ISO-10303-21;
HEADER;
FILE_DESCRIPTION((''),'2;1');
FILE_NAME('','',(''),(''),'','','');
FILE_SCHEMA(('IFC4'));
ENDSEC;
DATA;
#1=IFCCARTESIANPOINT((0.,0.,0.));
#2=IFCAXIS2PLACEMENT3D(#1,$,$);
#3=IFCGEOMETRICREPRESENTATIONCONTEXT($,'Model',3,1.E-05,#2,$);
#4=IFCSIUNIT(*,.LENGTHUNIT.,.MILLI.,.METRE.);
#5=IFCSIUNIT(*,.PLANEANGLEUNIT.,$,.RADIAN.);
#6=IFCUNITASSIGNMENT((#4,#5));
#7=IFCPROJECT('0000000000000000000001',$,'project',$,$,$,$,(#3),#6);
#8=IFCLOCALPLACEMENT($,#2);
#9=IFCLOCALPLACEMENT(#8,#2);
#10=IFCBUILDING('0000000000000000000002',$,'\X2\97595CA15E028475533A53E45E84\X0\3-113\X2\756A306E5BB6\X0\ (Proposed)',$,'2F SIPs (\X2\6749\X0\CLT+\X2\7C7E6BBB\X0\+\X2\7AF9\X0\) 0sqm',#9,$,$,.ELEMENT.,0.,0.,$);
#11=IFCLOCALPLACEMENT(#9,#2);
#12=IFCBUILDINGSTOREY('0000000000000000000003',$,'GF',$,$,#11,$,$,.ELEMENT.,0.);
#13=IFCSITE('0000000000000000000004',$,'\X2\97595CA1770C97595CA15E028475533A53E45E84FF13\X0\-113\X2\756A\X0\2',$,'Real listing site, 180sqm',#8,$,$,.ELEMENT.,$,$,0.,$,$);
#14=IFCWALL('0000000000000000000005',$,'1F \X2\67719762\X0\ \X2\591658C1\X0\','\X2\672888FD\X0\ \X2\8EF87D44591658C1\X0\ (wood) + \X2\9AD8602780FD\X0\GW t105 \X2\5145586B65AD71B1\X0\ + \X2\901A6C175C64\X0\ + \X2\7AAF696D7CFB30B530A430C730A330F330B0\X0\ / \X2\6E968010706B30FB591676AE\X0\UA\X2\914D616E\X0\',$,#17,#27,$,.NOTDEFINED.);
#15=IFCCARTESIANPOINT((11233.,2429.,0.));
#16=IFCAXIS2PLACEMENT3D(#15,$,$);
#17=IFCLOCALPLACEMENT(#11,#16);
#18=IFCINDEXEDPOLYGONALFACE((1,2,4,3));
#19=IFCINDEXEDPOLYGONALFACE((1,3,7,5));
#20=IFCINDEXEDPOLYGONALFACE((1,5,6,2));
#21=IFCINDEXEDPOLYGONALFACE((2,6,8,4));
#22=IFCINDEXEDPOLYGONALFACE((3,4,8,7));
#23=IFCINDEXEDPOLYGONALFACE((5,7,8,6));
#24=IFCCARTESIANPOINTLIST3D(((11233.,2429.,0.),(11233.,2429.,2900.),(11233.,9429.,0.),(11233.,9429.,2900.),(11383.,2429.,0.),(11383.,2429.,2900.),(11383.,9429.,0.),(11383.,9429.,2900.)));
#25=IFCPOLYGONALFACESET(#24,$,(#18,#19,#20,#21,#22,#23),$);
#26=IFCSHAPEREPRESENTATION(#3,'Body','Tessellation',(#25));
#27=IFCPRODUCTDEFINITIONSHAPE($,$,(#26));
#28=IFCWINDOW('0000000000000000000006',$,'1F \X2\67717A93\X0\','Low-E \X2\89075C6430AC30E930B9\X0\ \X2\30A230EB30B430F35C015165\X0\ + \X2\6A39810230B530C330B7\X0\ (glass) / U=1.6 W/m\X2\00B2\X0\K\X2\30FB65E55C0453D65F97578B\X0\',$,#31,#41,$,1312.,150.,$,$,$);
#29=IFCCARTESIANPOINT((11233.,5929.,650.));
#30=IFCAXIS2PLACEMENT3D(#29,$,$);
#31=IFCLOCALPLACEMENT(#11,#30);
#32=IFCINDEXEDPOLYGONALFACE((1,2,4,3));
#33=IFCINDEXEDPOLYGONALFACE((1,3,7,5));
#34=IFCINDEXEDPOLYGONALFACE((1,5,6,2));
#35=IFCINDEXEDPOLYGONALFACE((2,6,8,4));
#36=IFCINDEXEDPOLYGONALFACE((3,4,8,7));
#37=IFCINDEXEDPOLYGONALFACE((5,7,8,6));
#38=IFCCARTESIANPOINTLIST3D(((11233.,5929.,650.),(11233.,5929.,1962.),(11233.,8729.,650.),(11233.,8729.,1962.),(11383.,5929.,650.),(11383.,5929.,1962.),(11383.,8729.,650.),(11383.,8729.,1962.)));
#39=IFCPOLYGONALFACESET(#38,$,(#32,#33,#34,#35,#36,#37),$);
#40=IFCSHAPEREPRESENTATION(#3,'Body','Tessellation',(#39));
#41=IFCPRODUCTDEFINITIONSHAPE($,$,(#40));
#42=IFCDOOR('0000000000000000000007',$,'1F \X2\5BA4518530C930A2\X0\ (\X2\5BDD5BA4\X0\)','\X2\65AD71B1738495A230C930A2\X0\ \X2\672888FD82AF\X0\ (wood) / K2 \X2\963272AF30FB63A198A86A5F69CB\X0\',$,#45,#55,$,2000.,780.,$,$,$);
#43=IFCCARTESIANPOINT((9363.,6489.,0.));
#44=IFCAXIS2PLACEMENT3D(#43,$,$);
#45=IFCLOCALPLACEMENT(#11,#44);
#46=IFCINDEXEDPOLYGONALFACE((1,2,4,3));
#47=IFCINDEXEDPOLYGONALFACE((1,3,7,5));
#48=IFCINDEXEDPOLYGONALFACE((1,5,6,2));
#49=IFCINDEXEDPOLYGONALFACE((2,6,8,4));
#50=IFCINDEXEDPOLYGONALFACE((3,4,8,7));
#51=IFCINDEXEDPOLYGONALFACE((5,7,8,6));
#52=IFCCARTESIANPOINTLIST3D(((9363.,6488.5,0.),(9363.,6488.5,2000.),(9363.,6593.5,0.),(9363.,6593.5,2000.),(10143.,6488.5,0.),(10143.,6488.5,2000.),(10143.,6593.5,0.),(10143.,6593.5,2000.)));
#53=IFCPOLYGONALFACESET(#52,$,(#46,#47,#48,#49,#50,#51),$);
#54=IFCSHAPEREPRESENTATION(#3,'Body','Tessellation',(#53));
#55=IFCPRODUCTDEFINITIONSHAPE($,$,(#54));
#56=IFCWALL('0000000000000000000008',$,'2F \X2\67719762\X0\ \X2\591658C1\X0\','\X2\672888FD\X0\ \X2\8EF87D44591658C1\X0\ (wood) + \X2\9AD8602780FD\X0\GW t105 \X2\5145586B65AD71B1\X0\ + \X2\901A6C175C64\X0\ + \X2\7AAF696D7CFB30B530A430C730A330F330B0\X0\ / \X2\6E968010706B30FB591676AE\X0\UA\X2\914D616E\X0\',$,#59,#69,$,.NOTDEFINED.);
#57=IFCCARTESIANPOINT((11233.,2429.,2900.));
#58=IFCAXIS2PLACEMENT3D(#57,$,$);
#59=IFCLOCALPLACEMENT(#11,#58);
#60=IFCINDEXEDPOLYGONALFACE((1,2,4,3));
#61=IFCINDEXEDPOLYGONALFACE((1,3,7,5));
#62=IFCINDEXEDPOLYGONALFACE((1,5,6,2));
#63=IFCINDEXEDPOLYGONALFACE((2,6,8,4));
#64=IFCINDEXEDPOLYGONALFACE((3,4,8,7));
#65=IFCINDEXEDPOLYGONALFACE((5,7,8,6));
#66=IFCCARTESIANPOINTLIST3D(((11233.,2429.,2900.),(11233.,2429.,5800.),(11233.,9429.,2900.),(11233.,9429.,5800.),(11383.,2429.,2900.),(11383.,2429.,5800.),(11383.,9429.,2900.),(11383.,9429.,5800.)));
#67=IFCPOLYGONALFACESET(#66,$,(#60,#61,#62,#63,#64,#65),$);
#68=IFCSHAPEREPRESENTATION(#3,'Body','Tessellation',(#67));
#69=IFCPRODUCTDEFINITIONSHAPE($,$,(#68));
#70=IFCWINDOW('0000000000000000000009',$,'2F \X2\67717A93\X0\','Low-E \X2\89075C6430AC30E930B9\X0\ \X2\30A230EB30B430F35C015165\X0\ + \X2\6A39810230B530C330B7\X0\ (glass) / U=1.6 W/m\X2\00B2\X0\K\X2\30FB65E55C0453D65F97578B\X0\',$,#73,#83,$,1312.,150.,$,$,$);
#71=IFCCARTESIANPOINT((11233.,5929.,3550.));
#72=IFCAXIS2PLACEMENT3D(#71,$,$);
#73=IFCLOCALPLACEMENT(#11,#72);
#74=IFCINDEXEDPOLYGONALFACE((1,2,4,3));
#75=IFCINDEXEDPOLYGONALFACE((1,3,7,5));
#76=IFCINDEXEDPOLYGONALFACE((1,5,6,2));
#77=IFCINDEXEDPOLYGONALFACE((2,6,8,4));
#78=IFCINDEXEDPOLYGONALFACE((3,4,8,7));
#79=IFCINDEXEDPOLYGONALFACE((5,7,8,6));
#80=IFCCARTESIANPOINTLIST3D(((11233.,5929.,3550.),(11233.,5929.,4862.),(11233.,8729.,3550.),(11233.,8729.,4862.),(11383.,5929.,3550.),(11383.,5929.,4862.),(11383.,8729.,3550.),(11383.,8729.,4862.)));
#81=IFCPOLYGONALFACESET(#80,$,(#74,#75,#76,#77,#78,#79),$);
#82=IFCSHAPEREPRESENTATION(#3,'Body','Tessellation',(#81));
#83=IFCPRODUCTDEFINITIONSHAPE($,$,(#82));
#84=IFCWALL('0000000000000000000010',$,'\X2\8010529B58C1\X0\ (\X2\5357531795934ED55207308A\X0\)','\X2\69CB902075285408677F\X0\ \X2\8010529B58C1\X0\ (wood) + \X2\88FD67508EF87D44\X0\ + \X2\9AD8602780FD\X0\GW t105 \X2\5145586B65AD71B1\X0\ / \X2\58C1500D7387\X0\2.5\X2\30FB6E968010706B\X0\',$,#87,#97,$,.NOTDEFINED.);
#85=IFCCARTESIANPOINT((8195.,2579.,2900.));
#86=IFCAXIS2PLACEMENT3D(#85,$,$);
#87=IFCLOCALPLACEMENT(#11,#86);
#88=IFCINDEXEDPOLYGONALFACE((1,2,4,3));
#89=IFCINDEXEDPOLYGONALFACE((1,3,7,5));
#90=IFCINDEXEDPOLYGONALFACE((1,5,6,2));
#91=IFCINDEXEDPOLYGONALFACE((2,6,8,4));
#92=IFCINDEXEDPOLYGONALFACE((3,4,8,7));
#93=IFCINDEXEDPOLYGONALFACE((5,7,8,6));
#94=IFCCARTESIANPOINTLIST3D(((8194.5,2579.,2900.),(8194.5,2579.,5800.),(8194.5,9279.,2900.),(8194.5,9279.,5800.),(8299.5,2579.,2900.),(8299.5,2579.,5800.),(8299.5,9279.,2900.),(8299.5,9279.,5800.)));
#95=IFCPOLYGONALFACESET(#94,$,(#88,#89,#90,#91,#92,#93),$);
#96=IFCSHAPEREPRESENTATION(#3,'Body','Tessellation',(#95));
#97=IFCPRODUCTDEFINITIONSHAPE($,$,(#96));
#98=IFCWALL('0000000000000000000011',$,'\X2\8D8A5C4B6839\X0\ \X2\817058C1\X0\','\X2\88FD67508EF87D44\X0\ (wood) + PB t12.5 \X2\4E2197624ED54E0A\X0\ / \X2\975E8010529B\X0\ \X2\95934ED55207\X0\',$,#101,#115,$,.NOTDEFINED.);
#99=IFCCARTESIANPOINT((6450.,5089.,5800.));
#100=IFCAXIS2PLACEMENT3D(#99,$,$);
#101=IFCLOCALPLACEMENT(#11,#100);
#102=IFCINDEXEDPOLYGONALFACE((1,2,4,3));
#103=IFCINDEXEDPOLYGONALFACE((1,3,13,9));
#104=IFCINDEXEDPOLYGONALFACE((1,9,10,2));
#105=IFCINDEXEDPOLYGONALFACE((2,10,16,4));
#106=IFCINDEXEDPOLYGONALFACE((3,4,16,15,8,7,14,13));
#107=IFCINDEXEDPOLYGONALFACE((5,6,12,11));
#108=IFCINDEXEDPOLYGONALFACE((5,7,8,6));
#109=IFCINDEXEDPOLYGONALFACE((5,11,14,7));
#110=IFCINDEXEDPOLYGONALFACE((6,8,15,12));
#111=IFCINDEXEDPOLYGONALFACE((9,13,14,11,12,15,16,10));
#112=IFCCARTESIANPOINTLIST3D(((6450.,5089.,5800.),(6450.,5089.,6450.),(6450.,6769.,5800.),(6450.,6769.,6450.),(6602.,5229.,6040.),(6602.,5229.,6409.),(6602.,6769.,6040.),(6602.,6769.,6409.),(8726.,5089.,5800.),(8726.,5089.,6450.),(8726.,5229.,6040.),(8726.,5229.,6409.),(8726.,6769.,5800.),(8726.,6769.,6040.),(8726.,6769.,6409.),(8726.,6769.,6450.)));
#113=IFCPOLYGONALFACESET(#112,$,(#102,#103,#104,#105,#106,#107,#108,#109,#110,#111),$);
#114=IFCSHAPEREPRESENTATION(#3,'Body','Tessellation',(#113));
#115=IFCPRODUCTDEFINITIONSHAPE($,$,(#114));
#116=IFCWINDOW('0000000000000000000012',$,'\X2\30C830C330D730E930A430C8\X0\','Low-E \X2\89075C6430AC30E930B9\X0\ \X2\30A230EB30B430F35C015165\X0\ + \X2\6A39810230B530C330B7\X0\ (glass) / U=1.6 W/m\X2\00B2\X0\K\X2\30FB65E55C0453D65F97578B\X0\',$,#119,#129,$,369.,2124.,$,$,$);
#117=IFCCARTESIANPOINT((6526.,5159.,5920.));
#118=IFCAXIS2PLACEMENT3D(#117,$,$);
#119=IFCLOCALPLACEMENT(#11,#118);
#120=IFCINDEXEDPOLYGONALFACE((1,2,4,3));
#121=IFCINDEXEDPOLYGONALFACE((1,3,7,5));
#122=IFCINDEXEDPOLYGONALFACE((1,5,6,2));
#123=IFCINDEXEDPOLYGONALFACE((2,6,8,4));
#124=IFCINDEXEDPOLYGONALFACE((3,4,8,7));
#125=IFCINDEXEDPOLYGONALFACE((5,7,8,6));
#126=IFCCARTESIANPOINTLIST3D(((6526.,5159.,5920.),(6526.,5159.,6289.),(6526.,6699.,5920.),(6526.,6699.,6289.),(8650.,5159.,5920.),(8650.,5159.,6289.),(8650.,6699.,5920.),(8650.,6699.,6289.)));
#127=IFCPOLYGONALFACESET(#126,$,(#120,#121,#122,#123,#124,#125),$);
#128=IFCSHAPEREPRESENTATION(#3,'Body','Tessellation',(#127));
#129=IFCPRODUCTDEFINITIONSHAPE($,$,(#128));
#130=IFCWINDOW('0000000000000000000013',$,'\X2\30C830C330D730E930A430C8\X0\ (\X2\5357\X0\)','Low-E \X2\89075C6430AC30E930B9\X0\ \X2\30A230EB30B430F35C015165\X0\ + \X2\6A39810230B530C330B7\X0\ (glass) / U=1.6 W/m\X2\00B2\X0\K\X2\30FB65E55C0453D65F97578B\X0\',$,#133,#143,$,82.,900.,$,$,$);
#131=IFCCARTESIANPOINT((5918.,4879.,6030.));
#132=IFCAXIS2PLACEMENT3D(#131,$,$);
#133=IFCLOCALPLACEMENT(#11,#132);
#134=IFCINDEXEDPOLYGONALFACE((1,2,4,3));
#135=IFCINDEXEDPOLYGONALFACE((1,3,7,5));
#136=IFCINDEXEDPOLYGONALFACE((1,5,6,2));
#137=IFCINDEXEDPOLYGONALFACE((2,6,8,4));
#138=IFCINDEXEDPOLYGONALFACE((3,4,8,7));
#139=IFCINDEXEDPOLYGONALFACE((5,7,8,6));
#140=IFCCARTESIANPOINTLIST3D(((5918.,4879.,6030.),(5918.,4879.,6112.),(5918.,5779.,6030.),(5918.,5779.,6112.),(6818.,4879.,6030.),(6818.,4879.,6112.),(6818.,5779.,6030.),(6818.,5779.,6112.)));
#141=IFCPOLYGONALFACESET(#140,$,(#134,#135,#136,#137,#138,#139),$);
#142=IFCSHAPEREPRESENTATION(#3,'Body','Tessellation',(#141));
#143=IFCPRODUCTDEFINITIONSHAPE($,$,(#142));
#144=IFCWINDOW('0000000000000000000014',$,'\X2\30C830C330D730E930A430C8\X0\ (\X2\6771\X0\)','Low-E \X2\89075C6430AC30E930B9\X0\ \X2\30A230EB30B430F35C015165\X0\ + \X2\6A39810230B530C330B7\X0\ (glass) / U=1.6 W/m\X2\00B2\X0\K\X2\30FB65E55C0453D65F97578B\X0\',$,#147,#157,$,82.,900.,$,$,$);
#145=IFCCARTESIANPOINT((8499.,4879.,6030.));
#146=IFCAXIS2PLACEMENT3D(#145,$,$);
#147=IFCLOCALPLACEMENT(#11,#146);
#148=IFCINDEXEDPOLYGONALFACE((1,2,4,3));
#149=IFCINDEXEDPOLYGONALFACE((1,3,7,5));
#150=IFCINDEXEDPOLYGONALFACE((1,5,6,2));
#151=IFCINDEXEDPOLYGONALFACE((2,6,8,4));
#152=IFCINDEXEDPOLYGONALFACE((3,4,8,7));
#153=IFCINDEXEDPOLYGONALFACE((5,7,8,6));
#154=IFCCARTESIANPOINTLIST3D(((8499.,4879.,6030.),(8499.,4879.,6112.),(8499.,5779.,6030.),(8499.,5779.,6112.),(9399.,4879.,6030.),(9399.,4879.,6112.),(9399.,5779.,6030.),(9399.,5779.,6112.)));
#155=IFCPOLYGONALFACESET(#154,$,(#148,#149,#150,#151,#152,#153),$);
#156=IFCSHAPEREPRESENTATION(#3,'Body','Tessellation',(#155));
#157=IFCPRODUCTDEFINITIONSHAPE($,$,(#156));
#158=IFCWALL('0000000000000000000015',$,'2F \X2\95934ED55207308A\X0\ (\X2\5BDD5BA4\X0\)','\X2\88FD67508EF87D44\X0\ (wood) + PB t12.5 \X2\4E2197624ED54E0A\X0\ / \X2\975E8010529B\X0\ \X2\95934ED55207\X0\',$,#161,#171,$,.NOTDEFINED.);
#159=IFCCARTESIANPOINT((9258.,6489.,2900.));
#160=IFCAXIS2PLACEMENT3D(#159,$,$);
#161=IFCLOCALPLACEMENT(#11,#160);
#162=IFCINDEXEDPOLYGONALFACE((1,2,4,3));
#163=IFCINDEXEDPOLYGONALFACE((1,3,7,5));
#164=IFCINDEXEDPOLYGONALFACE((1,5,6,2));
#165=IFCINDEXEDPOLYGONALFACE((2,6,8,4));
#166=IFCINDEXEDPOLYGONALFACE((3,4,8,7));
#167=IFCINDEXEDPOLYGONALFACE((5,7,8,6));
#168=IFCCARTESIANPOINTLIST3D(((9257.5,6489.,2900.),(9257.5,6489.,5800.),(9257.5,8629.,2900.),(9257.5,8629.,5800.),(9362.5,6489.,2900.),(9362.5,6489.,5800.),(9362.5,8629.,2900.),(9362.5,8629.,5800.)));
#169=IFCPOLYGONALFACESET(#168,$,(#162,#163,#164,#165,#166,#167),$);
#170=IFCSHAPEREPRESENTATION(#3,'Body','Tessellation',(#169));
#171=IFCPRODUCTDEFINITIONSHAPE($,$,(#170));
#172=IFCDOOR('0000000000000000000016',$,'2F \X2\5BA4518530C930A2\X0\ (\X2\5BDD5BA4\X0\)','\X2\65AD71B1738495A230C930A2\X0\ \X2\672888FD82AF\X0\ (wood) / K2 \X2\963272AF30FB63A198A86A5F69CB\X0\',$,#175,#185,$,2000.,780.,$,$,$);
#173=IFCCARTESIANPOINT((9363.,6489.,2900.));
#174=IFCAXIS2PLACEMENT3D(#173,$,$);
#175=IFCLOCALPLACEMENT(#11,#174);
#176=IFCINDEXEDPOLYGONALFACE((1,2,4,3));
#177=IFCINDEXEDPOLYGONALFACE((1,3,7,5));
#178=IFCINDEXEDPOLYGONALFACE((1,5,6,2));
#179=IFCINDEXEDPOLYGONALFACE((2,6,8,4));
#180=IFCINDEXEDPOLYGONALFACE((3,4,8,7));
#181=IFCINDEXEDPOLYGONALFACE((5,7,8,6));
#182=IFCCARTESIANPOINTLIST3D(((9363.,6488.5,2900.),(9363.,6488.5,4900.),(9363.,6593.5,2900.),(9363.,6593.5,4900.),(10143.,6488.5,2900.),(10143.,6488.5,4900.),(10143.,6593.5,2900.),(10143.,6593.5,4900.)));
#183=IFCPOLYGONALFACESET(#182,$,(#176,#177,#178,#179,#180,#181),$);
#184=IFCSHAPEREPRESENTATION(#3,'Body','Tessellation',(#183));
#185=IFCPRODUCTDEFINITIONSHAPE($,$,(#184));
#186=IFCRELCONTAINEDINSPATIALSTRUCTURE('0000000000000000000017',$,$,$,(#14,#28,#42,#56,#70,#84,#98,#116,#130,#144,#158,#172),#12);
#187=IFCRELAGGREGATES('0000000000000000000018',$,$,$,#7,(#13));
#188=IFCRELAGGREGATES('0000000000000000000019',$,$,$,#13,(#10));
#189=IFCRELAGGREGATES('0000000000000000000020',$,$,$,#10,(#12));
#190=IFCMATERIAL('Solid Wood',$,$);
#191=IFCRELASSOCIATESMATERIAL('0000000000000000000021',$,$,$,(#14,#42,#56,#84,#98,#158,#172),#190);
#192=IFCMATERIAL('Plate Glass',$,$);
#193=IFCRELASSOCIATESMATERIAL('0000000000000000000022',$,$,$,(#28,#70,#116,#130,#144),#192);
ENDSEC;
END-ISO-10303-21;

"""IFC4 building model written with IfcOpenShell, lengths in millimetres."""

from ifc_helpers import new_model, si_unit, frame, frame_2d, origin, place, context, project, spatial, rectangle, extrude, material, element, fill, save


model = new_model("IFC4")

# Units and contexts
model_context = context("Model", 3, precision=1e-05, world=origin())
ifc_project = project(units=[si_unit("LENGTHUNIT", "METRE", prefix="MILLI"), si_unit("PLANEANGLEUNIT", "RADIAN")], contexts=[model_context])

# Site, building, storey
site_placement = place(None, origin())
site = spatial("IfcSite", under=ifc_project, at=site_placement, Name="静岡県静岡市葵区古庄３-113番2", ObjectType="Real listing site, 180sqm", CompositionType="ELEMENT", RefElevation=0.0)
building_placement = place(site_placement, origin())
building = spatial("IfcBuilding", under=site, at=building_placement, Name="静岡市葵区古庄3-113番の家 (Proposed)", ObjectType="2F SIPs (杉CLT+籾殻+竹) 0sqm", CompositionType="ELEMENT", ElevationOfRefHeight=0.0, ElevationOfTerrain=0.0)
storey_placement = place(building_placement, origin())
storey = spatial("IfcBuildingStorey", under=building, at=storey_placement, Name="GF", CompositionType="ELEMENT", Elevation=0.0)

# Wall, opening, window
ifc_material_1 = material(Name="Solid Wood")
wall_1_placement = place(storey_placement, frame((11233.0, 2429.0, 0.0)))
wall_1 = element("IfcWall", 1, at=wall_1_placement, inside=storey, material=ifc_material_1, Name="1F 東面 外壁", Description="木製 軸組外壁 (wood) + 高性能GW t105 充填断熱 + 通気層 + 窯業系サイディング / 準耐火・外皮UA配慮", PredefinedType="NOTDEFINED", context=model_context, shape_type="SweptSolid", body=[
    extrude(rectangle(XDim=150.0, YDim=7000.0, at=frame_2d((75.0, 3500.0))), frame((11233.0, 2429.0, 0.0)), (0.0, 0.0, 1.0), 2900.0),
])
opening_1_placement = place(storey_placement, frame((11233.0, 5929.0, 650.0)))
opening_1 = element("IfcOpeningElement", 2, at=opening_1_placement, cuts=wall_1, PredefinedType="NOTDEFINED", context=model_context, shape_type="SweptSolid", body=[
    extrude(rectangle(XDim=150.0, YDim=2800.0, at=frame_2d((75.0, 1400.0))), frame((11233.0, 5929.0, 650.0)), (0.0, 0.0, 1.0), 1312.0),
])
ifc_material_2 = material(Name="Plate Glass")
window_1_placement = place(storey_placement, frame((11233.0, 5929.0, 650.0)))
window_1 = element("IfcWindow", 3, at=window_1_placement, inside=storey, material=ifc_material_2, Name="1F 東窓", Description="Low-E 複層ガラス アルゴン封入 + 樹脂サッシ (glass) / U=1.6 W/m²K・日射取得型", OverallHeight=1312.0, OverallWidth=150.0, context=model_context, shape_type="SweptSolid", body=[
    extrude(rectangle(XDim=150.0, YDim=2800.0, at=frame_2d((75.0, 1400.0))), frame((11233.0, 5929.0, 650.0)), (0.0, 0.0, 1.0), 1312.0),
])
fill(opening_1, window_1)

# Door
door_1_placement = place(storey_placement, frame((9363.0, 6489.0, 0.0)))
element("IfcDoor", 4, at=door_1_placement, inside=storey, material=ifc_material_1, Name="1F 室内ドア (寝室)", Description="断熱玄関ドア 木製芯 (wood) / K2 防犯・採風機構", OverallHeight=2000.0, OverallWidth=780.0, context=model_context, shape_type="SweptSolid", body=[
    extrude(rectangle(XDim=780.0, YDim=105.0, at=frame_2d((390.0, 52.0))), frame((9363.0, 6489.0, 0.0)), (0.0, 0.0, 1.0), 2000.0),
])

# Wall, opening, window
wall_2_placement = place(storey_placement, frame((11233.0, 2429.0, 2900.0)))
wall_2 = element("IfcWall", 5, at=wall_2_placement, inside=storey, material=ifc_material_1, Name="2F 東面 外壁", Description="木製 軸組外壁 (wood) + 高性能GW t105 充填断熱 + 通気層 + 窯業系サイディング / 準耐火・外皮UA配慮", PredefinedType="NOTDEFINED", context=model_context, shape_type="SweptSolid", body=[
    extrude(rectangle(XDim=150.0, YDim=7000.0, at=frame_2d((75.0, 3500.0))), frame((11233.0, 2429.0, 2900.0)), (0.0, 0.0, 1.0), 2900.0),
])
opening_2_placement = place(storey_placement, frame((11233.0, 5929.0, 3550.0)))
opening_2 = element("IfcOpeningElement", 6, at=opening_2_placement, cuts=wall_2, PredefinedType="NOTDEFINED", context=model_context, shape_type="SweptSolid", body=[
    extrude(rectangle(XDim=150.0, YDim=2800.0, at=frame_2d((75.0, 1400.0))), frame((11233.0, 5929.0, 3550.0)), (0.0, 0.0, 1.0), 1312.0),
])
window_2_placement = place(storey_placement, frame((11233.0, 5929.0, 3550.0)))
window_2 = element("IfcWindow", 7, at=window_2_placement, inside=storey, material=ifc_material_2, Name="2F 東窓", Description="Low-E 複層ガラス アルゴン封入 + 樹脂サッシ (glass) / U=1.6 W/m²K・日射取得型", OverallHeight=1312.0, OverallWidth=150.0, context=model_context, shape_type="SweptSolid", body=[
    extrude(rectangle(XDim=150.0, YDim=2800.0, at=frame_2d((75.0, 1400.0))), frame((11233.0, 5929.0, 3550.0)), (0.0, 0.0, 1.0), 1312.0),
])
fill(opening_2, window_2)

# Wall
wall_3_placement = place(storey_placement, frame((8195.0, 2579.0, 2900.0)))
element("IfcWall", 8, at=wall_3_placement, inside=storey, material=ifc_material_1, Name="耐力壁 (南北間仕切り)", Description="構造用合板 耐力壁 (wood) + 製材軸組 + 高性能GW t105 充填断熱 / 壁倍率2.5・準耐火", PredefinedType="NOTDEFINED", context=model_context, shape_type="SweptSolid", body=[
    extrude(rectangle(XDim=105.0, YDim=6700.0, at=frame_2d((52.0, 3350.0))), frame((8195.0, 2579.0, 2900.0)), (0.0, 0.0, 1.0), 2900.0),
])

# Wall, openings, windows
wall_4_placement = place(storey_placement, frame((6450.0, 5089.0, 5800.0)))
wall_4 = element("IfcWall", 9, at=wall_4_placement, inside=storey, material=ifc_material_1, Name="越屋根 腰壁", Description="製材軸組 (wood) + PB t12.5 両面仕上 / 非耐力 間仕切", PredefinedType="NOTDEFINED", context=model_context, shape_type="SweptSolid", body=[
    extrude(rectangle(XDim=2276.0, YDim=1680.0, at=frame_2d((1138.0, 840.0))), frame((6450.0, 5089.0, 5800.0)), (0.0, 0.0, 1.0), 650.0),
])
opening_3_placement = place(storey_placement, frame((6526.0, 5159.0, 5920.0)))
opening_3 = element("IfcOpeningElement", 10, at=opening_3_placement, cuts=wall_4, PredefinedType="NOTDEFINED", context=model_context, shape_type="SweptSolid", body=[
    extrude(rectangle(XDim=2124.0, YDim=1540.0, at=frame_2d((1062.0, 770.0))), frame((6526.0, 5159.0, 5920.0)), (0.0, 0.0, 1.0), 369.0),
])
opening_4_placement = place(storey_placement, frame((5918.0, 4879.0, 6030.0)))
opening_4 = element("IfcOpeningElement", 11, at=opening_4_placement, cuts=wall_4, PredefinedType="NOTDEFINED", context=model_context, shape_type="SweptSolid", body=[
    extrude(rectangle(XDim=900.0, YDim=900.0, at=frame_2d((450.0, 450.0))), frame((5918.0, 4879.0, 6030.0)), (0.0, 0.0, 1.0), 82.0),
])
opening_5_placement = place(storey_placement, frame((8499.0, 4879.0, 6030.0)))
opening_5 = element("IfcOpeningElement", 12, at=opening_5_placement, cuts=wall_4, PredefinedType="NOTDEFINED", context=model_context, shape_type="SweptSolid", body=[
    extrude(rectangle(XDim=900.0, YDim=900.0, at=frame_2d((450.0, 450.0))), frame((8499.0, 4879.0, 6030.0)), (0.0, 0.0, 1.0), 82.0),
])
window_3_placement = place(storey_placement, frame((6526.0, 5159.0, 5920.0)))
window_3 = element("IfcWindow", 13, at=window_3_placement, inside=storey, material=ifc_material_2, Name="トップライト", Description="Low-E 複層ガラス アルゴン封入 + 樹脂サッシ (glass) / U=1.6 W/m²K・日射取得型", OverallHeight=369.0, OverallWidth=2124.0, context=model_context, shape_type="SweptSolid", body=[
    extrude(rectangle(XDim=2124.0, YDim=1540.0, at=frame_2d((1062.0, 770.0))), frame((6526.0, 5159.0, 5920.0)), (0.0, 0.0, 1.0), 369.0),
])
fill(opening_3, window_3)
window_4_placement = place(storey_placement, frame((5918.0, 4879.0, 6030.0)))
window_4 = element("IfcWindow", 14, at=window_4_placement, inside=storey, material=ifc_material_2, Name="トップライト (南)", Description="Low-E 複層ガラス アルゴン封入 + 樹脂サッシ (glass) / U=1.6 W/m²K・日射取得型", OverallHeight=82.0, OverallWidth=900.0, context=model_context, shape_type="SweptSolid", body=[
    extrude(rectangle(XDim=900.0, YDim=900.0, at=frame_2d((450.0, 450.0))), frame((5918.0, 4879.0, 6030.0)), (0.0, 0.0, 1.0), 82.0),
])
fill(opening_4, window_4)
window_5_placement = place(storey_placement, frame((8499.0, 4879.0, 6030.0)))
window_5 = element("IfcWindow", 15, at=window_5_placement, inside=storey, material=ifc_material_2, Name="トップライト (東)", Description="Low-E 複層ガラス アルゴン封入 + 樹脂サッシ (glass) / U=1.6 W/m²K・日射取得型", OverallHeight=82.0, OverallWidth=900.0, context=model_context, shape_type="SweptSolid", body=[
    extrude(rectangle(XDim=900.0, YDim=900.0, at=frame_2d((450.0, 450.0))), frame((8499.0, 4879.0, 6030.0)), (0.0, 0.0, 1.0), 82.0),
])
fill(opening_5, window_5)

# Wall
wall_5_placement = place(storey_placement, frame((9258.0, 6489.0, 2900.0)))
element("IfcWall", 16, at=wall_5_placement, inside=storey, material=ifc_material_1, Name="2F 間仕切り (寝室)", Description="製材軸組 (wood) + PB t12.5 両面仕上 / 非耐力 間仕切", PredefinedType="NOTDEFINED", context=model_context, shape_type="SweptSolid", body=[
    extrude(rectangle(XDim=105.0, YDim=2140.0, at=frame_2d((52.0, 1070.0))), frame((9258.0, 6489.0, 2900.0)), (0.0, 0.0, 1.0), 2900.0),
])

# Door
door_2_placement = place(storey_placement, frame((9363.0, 6489.0, 2900.0)))
element("IfcDoor", 17, at=door_2_placement, inside=storey, material=ifc_material_1, Name="2F 室内ドア (寝室)", Description="断熱玄関ドア 木製芯 (wood) / K2 防犯・採風機構", OverallHeight=2000.0, OverallWidth=780.0, context=model_context, shape_type="SweptSolid", body=[
    extrude(rectangle(XDim=780.0, YDim=105.0, at=frame_2d((390.0, 52.0))), frame((9363.0, 6489.0, 2900.0)), (0.0, 0.0, 1.0), 2000.0),
])

save(model, "model.ifc")
